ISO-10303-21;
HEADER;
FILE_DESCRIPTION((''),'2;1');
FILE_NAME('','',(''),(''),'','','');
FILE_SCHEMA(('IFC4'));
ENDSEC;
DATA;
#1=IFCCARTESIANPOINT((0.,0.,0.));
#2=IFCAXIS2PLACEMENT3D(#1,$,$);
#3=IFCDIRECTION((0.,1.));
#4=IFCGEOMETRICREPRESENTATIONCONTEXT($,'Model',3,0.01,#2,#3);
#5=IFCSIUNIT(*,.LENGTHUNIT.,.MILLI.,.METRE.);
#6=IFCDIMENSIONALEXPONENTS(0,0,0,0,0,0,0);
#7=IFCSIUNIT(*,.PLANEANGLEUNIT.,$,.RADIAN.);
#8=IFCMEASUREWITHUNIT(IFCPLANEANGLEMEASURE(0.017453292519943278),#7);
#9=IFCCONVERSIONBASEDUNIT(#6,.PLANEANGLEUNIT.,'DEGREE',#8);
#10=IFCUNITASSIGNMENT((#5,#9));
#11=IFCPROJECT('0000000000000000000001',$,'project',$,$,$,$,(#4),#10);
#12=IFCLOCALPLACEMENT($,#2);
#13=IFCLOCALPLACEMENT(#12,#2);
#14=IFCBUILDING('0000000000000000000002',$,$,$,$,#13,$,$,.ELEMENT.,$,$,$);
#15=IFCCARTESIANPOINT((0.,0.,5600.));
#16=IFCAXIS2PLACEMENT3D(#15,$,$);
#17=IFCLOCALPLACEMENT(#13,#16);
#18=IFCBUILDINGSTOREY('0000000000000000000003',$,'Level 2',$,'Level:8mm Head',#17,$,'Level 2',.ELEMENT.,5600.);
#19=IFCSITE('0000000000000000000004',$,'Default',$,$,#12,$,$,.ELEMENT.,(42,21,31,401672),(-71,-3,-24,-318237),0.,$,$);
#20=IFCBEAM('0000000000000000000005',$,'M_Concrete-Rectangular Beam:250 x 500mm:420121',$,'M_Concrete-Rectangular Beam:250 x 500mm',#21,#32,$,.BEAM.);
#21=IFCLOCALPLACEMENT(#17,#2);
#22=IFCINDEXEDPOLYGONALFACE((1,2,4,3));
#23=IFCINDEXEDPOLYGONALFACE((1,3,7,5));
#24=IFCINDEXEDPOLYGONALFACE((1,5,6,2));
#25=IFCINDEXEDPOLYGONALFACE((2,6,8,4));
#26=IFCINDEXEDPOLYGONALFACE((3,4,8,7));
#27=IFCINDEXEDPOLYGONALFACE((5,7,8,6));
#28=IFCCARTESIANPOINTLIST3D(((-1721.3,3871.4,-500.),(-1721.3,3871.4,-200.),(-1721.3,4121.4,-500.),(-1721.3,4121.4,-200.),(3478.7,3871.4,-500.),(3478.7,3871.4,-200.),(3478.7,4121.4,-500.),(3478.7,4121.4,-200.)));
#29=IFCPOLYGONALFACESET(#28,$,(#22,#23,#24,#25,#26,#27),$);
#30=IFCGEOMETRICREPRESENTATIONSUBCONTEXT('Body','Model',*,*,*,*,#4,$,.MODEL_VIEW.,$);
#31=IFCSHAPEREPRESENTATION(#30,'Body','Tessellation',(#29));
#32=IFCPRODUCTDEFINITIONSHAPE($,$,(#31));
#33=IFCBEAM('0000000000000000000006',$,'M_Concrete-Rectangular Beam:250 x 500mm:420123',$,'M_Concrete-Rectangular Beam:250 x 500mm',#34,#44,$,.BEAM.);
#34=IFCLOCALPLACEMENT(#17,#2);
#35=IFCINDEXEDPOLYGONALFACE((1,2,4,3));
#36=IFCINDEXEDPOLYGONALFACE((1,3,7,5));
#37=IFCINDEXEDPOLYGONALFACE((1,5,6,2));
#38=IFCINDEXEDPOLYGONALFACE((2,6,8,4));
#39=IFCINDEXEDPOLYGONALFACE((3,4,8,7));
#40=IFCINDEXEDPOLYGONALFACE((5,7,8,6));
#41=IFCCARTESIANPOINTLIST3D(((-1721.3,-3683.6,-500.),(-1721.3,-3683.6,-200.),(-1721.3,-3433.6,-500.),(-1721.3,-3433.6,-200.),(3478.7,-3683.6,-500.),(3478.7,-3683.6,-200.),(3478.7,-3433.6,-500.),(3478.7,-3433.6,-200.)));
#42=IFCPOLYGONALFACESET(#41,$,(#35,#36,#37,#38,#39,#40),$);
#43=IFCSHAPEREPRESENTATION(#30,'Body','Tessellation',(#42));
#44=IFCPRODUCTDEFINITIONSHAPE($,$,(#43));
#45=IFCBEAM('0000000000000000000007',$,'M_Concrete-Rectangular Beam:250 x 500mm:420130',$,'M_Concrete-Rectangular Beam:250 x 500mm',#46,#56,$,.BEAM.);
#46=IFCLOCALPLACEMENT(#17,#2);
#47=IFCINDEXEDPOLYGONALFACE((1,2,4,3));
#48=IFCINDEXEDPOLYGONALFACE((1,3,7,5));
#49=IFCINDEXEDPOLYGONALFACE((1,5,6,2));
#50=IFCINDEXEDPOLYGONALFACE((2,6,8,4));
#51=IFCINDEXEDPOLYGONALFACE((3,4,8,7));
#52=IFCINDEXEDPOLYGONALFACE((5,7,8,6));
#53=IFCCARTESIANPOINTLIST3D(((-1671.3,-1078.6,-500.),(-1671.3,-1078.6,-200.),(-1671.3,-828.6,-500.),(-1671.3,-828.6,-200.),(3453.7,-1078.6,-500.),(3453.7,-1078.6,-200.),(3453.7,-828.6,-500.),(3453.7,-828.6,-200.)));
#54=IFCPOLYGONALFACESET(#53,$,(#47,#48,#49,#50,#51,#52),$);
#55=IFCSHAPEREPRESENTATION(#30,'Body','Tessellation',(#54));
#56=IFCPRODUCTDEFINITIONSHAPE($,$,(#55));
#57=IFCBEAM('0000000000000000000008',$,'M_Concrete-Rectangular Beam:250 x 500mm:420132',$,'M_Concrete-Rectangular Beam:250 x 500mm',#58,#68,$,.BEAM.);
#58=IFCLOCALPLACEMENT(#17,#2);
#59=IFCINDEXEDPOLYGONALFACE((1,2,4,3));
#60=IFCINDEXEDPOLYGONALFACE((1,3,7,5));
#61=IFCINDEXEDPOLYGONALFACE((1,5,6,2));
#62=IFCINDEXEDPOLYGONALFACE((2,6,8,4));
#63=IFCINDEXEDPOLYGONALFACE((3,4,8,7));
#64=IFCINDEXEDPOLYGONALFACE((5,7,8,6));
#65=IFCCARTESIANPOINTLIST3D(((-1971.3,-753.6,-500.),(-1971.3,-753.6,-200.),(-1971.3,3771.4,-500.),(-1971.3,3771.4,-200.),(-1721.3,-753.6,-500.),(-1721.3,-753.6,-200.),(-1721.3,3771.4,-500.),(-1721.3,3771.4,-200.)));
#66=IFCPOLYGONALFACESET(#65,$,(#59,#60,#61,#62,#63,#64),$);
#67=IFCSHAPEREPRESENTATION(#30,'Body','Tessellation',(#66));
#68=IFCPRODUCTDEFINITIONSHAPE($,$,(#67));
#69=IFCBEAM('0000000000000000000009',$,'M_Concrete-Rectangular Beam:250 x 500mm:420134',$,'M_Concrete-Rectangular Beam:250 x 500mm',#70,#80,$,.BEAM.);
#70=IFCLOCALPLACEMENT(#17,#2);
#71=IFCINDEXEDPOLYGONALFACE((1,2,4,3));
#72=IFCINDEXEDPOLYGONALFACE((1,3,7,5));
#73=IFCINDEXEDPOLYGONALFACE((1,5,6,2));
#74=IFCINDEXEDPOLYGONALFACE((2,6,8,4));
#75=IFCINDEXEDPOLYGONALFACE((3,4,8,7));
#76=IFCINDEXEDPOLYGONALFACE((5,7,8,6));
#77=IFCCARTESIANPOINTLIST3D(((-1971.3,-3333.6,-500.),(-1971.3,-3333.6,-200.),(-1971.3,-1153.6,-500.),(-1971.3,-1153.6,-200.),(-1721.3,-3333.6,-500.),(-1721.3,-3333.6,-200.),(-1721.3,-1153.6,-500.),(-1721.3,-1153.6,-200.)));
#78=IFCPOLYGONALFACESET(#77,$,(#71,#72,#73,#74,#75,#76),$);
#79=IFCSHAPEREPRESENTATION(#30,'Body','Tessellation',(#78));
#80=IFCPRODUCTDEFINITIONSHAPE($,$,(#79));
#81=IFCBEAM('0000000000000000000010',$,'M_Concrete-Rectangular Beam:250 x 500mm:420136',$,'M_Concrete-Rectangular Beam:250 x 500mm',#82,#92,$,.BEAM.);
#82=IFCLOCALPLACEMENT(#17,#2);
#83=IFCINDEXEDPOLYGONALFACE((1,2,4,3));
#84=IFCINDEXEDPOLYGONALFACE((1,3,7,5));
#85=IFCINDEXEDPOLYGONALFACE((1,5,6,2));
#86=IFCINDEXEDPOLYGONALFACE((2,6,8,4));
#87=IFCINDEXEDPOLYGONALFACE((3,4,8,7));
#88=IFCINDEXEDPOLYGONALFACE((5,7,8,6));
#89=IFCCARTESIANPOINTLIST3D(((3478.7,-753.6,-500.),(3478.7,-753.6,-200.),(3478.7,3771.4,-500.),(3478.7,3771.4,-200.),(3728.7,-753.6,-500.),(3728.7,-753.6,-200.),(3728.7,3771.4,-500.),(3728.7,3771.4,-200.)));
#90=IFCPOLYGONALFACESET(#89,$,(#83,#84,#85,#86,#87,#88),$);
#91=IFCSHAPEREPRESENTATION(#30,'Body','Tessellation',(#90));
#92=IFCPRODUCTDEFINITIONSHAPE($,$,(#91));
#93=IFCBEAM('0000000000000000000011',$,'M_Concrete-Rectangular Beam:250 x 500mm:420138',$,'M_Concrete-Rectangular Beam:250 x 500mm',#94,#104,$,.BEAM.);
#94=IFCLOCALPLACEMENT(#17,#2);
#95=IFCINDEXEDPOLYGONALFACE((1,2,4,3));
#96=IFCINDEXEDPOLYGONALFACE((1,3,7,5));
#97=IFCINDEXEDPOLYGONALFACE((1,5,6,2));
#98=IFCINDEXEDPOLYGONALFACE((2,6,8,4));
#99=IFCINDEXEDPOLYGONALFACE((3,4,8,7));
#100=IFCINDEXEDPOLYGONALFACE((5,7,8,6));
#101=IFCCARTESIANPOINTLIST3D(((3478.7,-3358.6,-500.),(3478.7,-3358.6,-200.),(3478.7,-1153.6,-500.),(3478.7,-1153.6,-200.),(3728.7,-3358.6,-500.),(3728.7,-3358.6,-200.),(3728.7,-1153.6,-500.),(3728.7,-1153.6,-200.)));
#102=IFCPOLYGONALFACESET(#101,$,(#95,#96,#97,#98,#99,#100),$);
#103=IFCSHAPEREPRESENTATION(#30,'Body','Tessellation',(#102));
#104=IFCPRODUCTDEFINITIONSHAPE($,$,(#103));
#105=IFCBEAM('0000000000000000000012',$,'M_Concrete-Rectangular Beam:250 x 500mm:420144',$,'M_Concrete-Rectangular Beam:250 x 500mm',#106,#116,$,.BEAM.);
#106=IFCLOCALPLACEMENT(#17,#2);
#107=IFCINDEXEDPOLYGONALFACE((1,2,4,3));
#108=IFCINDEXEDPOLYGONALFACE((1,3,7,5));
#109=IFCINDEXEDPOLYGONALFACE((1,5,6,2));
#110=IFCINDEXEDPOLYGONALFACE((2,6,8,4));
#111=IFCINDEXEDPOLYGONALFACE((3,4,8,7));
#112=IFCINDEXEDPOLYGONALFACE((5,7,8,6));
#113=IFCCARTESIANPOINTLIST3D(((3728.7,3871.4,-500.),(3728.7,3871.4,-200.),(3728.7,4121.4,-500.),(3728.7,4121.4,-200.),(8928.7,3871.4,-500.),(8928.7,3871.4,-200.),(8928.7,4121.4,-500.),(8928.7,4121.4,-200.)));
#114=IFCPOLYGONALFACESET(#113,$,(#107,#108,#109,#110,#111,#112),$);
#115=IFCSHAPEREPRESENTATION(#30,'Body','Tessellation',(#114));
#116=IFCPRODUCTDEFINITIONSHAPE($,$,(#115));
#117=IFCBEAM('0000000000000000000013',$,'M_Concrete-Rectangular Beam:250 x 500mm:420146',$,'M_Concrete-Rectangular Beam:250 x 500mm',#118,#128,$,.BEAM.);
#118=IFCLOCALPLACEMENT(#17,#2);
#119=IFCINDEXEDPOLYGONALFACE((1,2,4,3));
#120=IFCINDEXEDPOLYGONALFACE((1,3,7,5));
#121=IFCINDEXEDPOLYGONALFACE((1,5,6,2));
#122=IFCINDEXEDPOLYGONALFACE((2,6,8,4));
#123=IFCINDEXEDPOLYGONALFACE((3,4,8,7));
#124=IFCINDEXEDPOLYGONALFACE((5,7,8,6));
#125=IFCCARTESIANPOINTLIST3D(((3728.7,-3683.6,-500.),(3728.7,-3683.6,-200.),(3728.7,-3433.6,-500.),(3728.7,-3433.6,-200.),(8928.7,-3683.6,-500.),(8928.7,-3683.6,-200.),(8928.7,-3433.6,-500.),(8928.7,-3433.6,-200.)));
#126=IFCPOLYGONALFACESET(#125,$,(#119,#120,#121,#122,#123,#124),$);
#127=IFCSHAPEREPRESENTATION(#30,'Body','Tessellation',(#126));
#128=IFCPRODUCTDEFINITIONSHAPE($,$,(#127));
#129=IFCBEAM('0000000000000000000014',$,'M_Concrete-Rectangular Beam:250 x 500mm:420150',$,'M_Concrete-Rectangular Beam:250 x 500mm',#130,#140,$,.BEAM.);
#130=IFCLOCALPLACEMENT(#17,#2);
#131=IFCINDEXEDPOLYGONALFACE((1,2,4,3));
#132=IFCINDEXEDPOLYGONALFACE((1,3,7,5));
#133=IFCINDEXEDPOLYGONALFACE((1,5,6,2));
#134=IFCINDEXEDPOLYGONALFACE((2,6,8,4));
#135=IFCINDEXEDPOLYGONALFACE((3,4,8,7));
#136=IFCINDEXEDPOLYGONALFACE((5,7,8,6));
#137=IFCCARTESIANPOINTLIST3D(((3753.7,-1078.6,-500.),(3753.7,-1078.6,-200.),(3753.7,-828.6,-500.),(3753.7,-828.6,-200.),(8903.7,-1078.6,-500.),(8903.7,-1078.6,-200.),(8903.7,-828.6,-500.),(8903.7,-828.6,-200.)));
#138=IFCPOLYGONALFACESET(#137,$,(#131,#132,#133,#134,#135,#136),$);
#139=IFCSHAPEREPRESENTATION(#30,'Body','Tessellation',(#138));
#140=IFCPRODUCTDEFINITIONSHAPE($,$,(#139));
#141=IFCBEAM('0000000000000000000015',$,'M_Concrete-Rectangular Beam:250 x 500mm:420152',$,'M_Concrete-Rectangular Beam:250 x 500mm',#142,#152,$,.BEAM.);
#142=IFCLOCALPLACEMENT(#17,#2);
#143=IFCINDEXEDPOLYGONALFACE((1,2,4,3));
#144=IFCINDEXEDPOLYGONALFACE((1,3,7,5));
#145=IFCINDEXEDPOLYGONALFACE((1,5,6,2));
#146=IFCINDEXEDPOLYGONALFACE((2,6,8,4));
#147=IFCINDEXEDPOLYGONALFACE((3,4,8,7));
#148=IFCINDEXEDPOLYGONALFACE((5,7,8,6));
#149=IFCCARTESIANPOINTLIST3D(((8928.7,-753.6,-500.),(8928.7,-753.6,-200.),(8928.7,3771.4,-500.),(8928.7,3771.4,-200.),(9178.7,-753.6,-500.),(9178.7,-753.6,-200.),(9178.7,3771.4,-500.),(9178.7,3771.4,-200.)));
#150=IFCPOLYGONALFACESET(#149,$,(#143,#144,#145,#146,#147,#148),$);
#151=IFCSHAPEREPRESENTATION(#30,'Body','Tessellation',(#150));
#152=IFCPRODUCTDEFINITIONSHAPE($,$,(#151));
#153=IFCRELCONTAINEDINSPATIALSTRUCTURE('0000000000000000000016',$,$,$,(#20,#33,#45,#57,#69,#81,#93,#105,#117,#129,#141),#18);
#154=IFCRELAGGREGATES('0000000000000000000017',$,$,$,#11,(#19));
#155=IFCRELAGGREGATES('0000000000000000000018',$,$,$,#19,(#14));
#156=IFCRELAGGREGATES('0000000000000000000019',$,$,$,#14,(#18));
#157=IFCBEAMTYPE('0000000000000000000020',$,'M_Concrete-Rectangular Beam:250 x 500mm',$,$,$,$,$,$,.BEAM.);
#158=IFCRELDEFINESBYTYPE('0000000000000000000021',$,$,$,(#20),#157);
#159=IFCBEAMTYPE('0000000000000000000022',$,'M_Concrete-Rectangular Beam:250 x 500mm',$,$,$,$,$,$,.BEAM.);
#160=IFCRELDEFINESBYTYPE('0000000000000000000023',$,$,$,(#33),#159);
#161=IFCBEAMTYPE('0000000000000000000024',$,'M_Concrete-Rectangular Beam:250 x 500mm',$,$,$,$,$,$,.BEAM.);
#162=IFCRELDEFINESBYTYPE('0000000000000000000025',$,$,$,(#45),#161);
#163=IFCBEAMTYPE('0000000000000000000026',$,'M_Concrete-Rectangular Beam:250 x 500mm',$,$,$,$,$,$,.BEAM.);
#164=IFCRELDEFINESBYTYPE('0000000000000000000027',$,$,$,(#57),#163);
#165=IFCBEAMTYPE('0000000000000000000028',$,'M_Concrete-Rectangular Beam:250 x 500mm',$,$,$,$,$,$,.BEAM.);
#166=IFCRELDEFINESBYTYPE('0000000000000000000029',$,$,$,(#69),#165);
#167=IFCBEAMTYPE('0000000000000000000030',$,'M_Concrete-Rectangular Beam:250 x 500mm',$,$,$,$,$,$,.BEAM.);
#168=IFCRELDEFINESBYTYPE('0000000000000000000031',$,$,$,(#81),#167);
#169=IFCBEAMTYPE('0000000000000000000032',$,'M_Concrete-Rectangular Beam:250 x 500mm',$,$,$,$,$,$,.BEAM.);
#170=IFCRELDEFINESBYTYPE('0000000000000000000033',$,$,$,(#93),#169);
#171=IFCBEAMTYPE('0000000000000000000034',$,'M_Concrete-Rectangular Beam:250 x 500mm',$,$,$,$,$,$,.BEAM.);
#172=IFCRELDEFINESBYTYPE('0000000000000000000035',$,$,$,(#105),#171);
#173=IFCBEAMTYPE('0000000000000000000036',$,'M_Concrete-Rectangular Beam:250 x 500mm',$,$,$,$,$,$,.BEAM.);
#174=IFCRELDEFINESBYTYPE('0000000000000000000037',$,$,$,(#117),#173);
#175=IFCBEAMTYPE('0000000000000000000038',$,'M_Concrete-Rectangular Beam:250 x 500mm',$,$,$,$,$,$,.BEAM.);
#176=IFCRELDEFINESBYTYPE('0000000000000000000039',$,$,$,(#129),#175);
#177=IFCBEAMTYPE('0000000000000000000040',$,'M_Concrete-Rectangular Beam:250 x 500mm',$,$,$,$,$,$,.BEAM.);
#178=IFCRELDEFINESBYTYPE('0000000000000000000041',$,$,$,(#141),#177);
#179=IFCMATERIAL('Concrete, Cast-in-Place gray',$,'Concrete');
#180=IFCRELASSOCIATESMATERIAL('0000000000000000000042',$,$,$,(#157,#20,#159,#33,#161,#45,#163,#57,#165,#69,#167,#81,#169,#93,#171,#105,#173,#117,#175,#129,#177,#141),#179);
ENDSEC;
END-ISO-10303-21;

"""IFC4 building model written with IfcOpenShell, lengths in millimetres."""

from ifc_helpers import new_model, entity, si_unit, converted_unit, direction, frame, origin, place, context, subcontext, project, spatial, indexed_curve, outline, extrude, source, transform, mapped, material, type_object, type_shapes, element, save


model = new_model("IFC4")

# Units and contexts
model_context = context("Model", 3, precision=0.01, world=origin(), true_north=direction((0.0, 1.0)))
body_context = subcontext(model_context, "Body", "Model", "MODEL_VIEW")
ifc_project = project(units=[si_unit("LENGTHUNIT", "METRE", prefix="MILLI"), converted_unit("PLANEANGLEUNIT", "DEGREE", entity("IfcPlaneAngleMeasure", 0.017453292519943278), si_unit("PLANEANGLEUNIT", "RADIAN"), dimensions=[0, 0, 0, 0, 0, 0, 0])], contexts=[model_context])

# Site, building, storey
site_placement = place(None, origin())
site = spatial("IfcSite", under=ifc_project, at=site_placement, Name="Default", CompositionType="ELEMENT", RefLatitude=(42, 21, 31, 401672), RefLongitude=(-71, -3, -24, -318237), RefElevation=0.0)
building_placement = place(site_placement, origin())
building = spatial("IfcBuilding", under=site, at=building_placement, CompositionType="ELEMENT")
storey_placement = place(building_placement, frame((0.0, 0.0, 5600.0)))
storey = spatial("IfcBuildingStorey", under=building, at=storey_placement, Name="Level 2", ObjectType="Level:8mm Head", LongName="Level 2", CompositionType="ELEMENT", Elevation=5600.0)

# Beams
ifc_material_1 = material(Name="Concrete, Cast-in-Place gray", Category="Concrete")
beam_type_1 = type_object("IfcBeamType", Name="M_Concrete-Rectangular Beam:250 x 500mm", PredefinedType="BEAM", material=ifc_material_1)
shared_shape_1 = source(origin(), body_context, "Body", "SweptSolid", [
    extrude(outline(indexed_curve([(-150.0, -125.0), (150.0, -125.0), (150.0, 125.0), (-150.0, 125.0), (-150.0, -125.0)], self_intersect=False)), frame((-1721.3, 3996.4, 5250.0), z_axis=(1.0, 0.0, 0.0), x_axis=(0.0, 0.0, -1.0)), (0.0, 0.0, 1.0), 5200.0),
])
type_shapes(beam_type_1, [shared_shape_1])
beam_1_placement = place(storey_placement, frame((0.0, 0.0, -5600.0)))
element("IfcBeam", 1, at=beam_1_placement, inside=storey, type_object=beam_type_1, material=ifc_material_1, Name="M_Concrete-Rectangular Beam:250 x 500mm:420121", ObjectType="M_Concrete-Rectangular Beam:250 x 500mm", PredefinedType="BEAM", context=body_context, shape_type="MappedRepresentation", body=[
    mapped(shared_shape_1, transform((0.0, 0.0, 0.0), scale=1.0)),
])
beam_type_2 = type_object("IfcBeamType", Name="M_Concrete-Rectangular Beam:250 x 500mm", PredefinedType="BEAM", material=ifc_material_1)
shared_shape_2 = source(origin(), body_context, "Body", "SweptSolid", [
    extrude(outline(indexed_curve([(-150.0, -125.0), (150.0, -125.0), (150.0, 125.0), (-150.0, 125.0), (-150.0, -125.0)], self_intersect=False)), frame((-1721.3, -3558.6, 5250.0), z_axis=(1.0, 0.0, 0.0), x_axis=(0.0, 0.0, -1.0)), (0.0, 0.0, 1.0), 5200.0),
])
type_shapes(beam_type_2, [shared_shape_2])
beam_2_placement = place(storey_placement, frame((0.0, 0.0, -5600.0)))
element("IfcBeam", 2, at=beam_2_placement, inside=storey, type_object=beam_type_2, material=ifc_material_1, Name="M_Concrete-Rectangular Beam:250 x 500mm:420123", ObjectType="M_Concrete-Rectangular Beam:250 x 500mm", PredefinedType="BEAM", context=body_context, shape_type="MappedRepresentation", body=[
    mapped(shared_shape_2, transform((0.0, 0.0, 0.0), scale=1.0)),
])
beam_type_3 = type_object("IfcBeamType", Name="M_Concrete-Rectangular Beam:250 x 500mm", PredefinedType="BEAM", material=ifc_material_1)
shared_shape_3 = source(origin(), body_context, "Body", "SweptSolid", [
    extrude(outline(indexed_curve([(-150.0, -125.0), (150.0, -125.0), (150.0, 125.0), (-150.0, 125.0), (-150.0, -125.0)], self_intersect=False)), frame((-1671.3, -953.6, 5250.0), z_axis=(1.0, 0.0, 0.0), x_axis=(0.0, 0.0, -1.0)), (0.0, 0.0, 1.0), 5125.0),
])
type_shapes(beam_type_3, [shared_shape_3])
beam_3_placement = place(storey_placement, frame((0.0, 0.0, -5600.0)))
element("IfcBeam", 3, at=beam_3_placement, inside=storey, type_object=beam_type_3, material=ifc_material_1, Name="M_Concrete-Rectangular Beam:250 x 500mm:420130", ObjectType="M_Concrete-Rectangular Beam:250 x 500mm", PredefinedType="BEAM", context=body_context, shape_type="MappedRepresentation", body=[
    mapped(shared_shape_3, transform((0.0, 0.0, 0.0), scale=1.0)),
])
beam_type_4 = type_object("IfcBeamType", Name="M_Concrete-Rectangular Beam:250 x 500mm", PredefinedType="BEAM", material=ifc_material_1)
shared_shape_4 = source(origin(), body_context, "Body", "SweptSolid", [
    extrude(outline(indexed_curve([(-125.0, -150.0), (125.0, -150.0), (125.0, 150.0), (-125.0, 150.0), (-125.0, -150.0)], self_intersect=False)), frame((-1846.3, 3771.4, 5250.0), z_axis=(0.0, -1.0, 0.0), x_axis=(-1.0, 0.0, 0.0)), (0.0, 0.0, 1.0), 4525.0),
])
type_shapes(beam_type_4, [shared_shape_4])
beam_4_placement = place(storey_placement, frame((0.0, 0.0, -5600.0)))
element("IfcBeam", 4, at=beam_4_placement, inside=storey, type_object=beam_type_4, material=ifc_material_1, Name="M_Concrete-Rectangular Beam:250 x 500mm:420132", ObjectType="M_Concrete-Rectangular Beam:250 x 500mm", PredefinedType="BEAM", context=body_context, shape_type="MappedRepresentation", body=[
    mapped(shared_shape_4, transform((0.0, 0.0, 0.0), scale=1.0)),
])
beam_type_5 = type_object("IfcBeamType", Name="M_Concrete-Rectangular Beam:250 x 500mm", PredefinedType="BEAM", material=ifc_material_1)
shared_shape_5 = source(origin(), body_context, "Body", "SweptSolid", [
    extrude(outline(indexed_curve([(-125.0, -150.0), (125.0, -150.0), (125.0, 150.0), (-125.0, 150.0), (-125.0, -150.0)], self_intersect=False)), frame((-1846.3, -1153.6, 5250.0), z_axis=(0.0, -1.0, 0.0), x_axis=(-1.0, 0.0, 0.0)), (0.0, 0.0, 1.0), 2180.0),
])
type_shapes(beam_type_5, [shared_shape_5])
beam_5_placement = place(storey_placement, frame((0.0, 0.0, -5600.0)))
element("IfcBeam", 5, at=beam_5_placement, inside=storey, type_object=beam_type_5, material=ifc_material_1, Name="M_Concrete-Rectangular Beam:250 x 500mm:420134", ObjectType="M_Concrete-Rectangular Beam:250 x 500mm", PredefinedType="BEAM", context=body_context, shape_type="MappedRepresentation", body=[
    mapped(shared_shape_5, transform((0.0, 0.0, 0.0), scale=1.0)),
])
beam_type_6 = type_object("IfcBeamType", Name="M_Concrete-Rectangular Beam:250 x 500mm", PredefinedType="BEAM", material=ifc_material_1)
shared_shape_6 = source(origin(), body_context, "Body", "SweptSolid", [
    extrude(outline(indexed_curve([(-125.0, -150.0), (125.0, -150.0), (125.0, 150.0), (-125.0, 150.0), (-125.0, -150.0)], self_intersect=False)), frame((3603.7, 3771.4, 5250.0), z_axis=(0.0, -1.0, 0.0), x_axis=(-1.0, 0.0, 0.0)), (0.0, 0.0, 1.0), 4525.0),
])
type_shapes(beam_type_6, [shared_shape_6])
beam_6_placement = place(storey_placement, frame((0.0, 0.0, -5600.0)))
element("IfcBeam", 6, at=beam_6_placement, inside=storey, type_object=beam_type_6, material=ifc_material_1, Name="M_Concrete-Rectangular Beam:250 x 500mm:420136", ObjectType="M_Concrete-Rectangular Beam:250 x 500mm", PredefinedType="BEAM", context=body_context, shape_type="MappedRepresentation", body=[
    mapped(shared_shape_6, transform((0.0, 0.0, 0.0), scale=1.0)),
])
beam_type_7 = type_object("IfcBeamType", Name="M_Concrete-Rectangular Beam:250 x 500mm", PredefinedType="BEAM", material=ifc_material_1)
shared_shape_7 = source(origin(), body_context, "Body", "SweptSolid", [
    extrude(outline(indexed_curve([(-125.0, -150.0), (125.0, -150.0), (125.0, 150.0), (-125.0, 150.0), (-125.0, -150.0)], self_intersect=False)), frame((3603.7, -1153.6, 5250.0), z_axis=(0.0, -1.0, 0.0), x_axis=(-1.0, 0.0, 0.0)), (0.0, 0.0, 1.0), 2205.0),
])
type_shapes(beam_type_7, [shared_shape_7])
beam_7_placement = place(storey_placement, frame((0.0, 0.0, -5600.0)))
element("IfcBeam", 7, at=beam_7_placement, inside=storey, type_object=beam_type_7, material=ifc_material_1, Name="M_Concrete-Rectangular Beam:250 x 500mm:420138", ObjectType="M_Concrete-Rectangular Beam:250 x 500mm", PredefinedType="BEAM", context=body_context, shape_type="MappedRepresentation", body=[
    mapped(shared_shape_7, transform((0.0, 0.0, 0.0), scale=1.0)),
])
beam_type_8 = type_object("IfcBeamType", Name="M_Concrete-Rectangular Beam:250 x 500mm", PredefinedType="BEAM", material=ifc_material_1)
shared_shape_8 = source(origin(), body_context, "Body", "SweptSolid", [
    extrude(outline(indexed_curve([(-150.0, -125.0), (150.0, -125.0), (150.0, 125.0), (-150.0, 125.0), (-150.0, -125.0)], self_intersect=False)), frame((3728.7, 3996.4, 5250.0), z_axis=(1.0, 0.0, 0.0), x_axis=(0.0, 0.0, -1.0)), (0.0, 0.0, 1.0), 5200.0),
])
type_shapes(beam_type_8, [shared_shape_8])
beam_8_placement = place(storey_placement, frame((0.0, 0.0, -5600.0)))
element("IfcBeam", 8, at=beam_8_placement, inside=storey, type_object=beam_type_8, material=ifc_material_1, Name="M_Concrete-Rectangular Beam:250 x 500mm:420144", ObjectType="M_Concrete-Rectangular Beam:250 x 500mm", PredefinedType="BEAM", context=body_context, shape_type="MappedRepresentation", body=[
    mapped(shared_shape_8, transform((0.0, 0.0, 0.0), scale=1.0)),
])
beam_type_9 = type_object("IfcBeamType", Name="M_Concrete-Rectangular Beam:250 x 500mm", PredefinedType="BEAM", material=ifc_material_1)
shared_shape_9 = source(origin(), body_context, "Body", "SweptSolid", [
    extrude(outline(indexed_curve([(-150.0, -125.0), (150.0, -125.0), (150.0, 125.0), (-150.0, 125.0), (-150.0, -125.0)], self_intersect=False)), frame((3728.7, -3558.6, 5250.0), z_axis=(1.0, 0.0, 0.0), x_axis=(0.0, 0.0, -1.0)), (0.0, 0.0, 1.0), 5200.0),
])
type_shapes(beam_type_9, [shared_shape_9])
beam_9_placement = place(storey_placement, frame((0.0, 0.0, -5600.0)))
element("IfcBeam", 9, at=beam_9_placement, inside=storey, type_object=beam_type_9, material=ifc_material_1, Name="M_Concrete-Rectangular Beam:250 x 500mm:420146", ObjectType="M_Concrete-Rectangular Beam:250 x 500mm", PredefinedType="BEAM", context=body_context, shape_type="MappedRepresentation", body=[
    mapped(shared_shape_9, transform((0.0, 0.0, 0.0), scale=1.0)),
])
beam_type_10 = type_object("IfcBeamType", Name="M_Concrete-Rectangular Beam:250 x 500mm", PredefinedType="BEAM", material=ifc_material_1)
shared_shape_10 = source(origin(), body_context, "Body", "SweptSolid", [
    extrude(outline(indexed_curve([(-150.0, -125.0), (150.0, -125.0), (150.0, 125.0), (-150.0, 125.0), (-150.0, -125.0)], self_intersect=False)), frame((3753.7, -953.6, 5250.0), z_axis=(1.0, 0.0, 0.0), x_axis=(0.0, 0.0, -1.0)), (0.0, 0.0, 1.0), 5150.0),
])
type_shapes(beam_type_10, [shared_shape_10])
beam_10_placement = place(storey_placement, frame((0.0, 0.0, -5600.0)))
element("IfcBeam", 10, at=beam_10_placement, inside=storey, type_object=beam_type_10, material=ifc_material_1, Name="M_Concrete-Rectangular Beam:250 x 500mm:420150", ObjectType="M_Concrete-Rectangular Beam:250 x 500mm", PredefinedType="BEAM", context=body_context, shape_type="MappedRepresentation", body=[
    mapped(shared_shape_10, transform((0.0, 0.0, 0.0), scale=1.0)),
])
beam_type_11 = type_object("IfcBeamType", Name="M_Concrete-Rectangular Beam:250 x 500mm", PredefinedType="BEAM", material=ifc_material_1)
shared_shape_11 = source(origin(), body_context, "Body", "SweptSolid", [
    extrude(outline(indexed_curve([(-125.0, -150.0), (125.0, -150.0), (125.0, 150.0), (-125.0, 150.0), (-125.0, -150.0)], self_intersect=False)), frame((9053.7, 3771.4, 5250.0), z_axis=(0.0, -1.0, 0.0), x_axis=(-1.0, 0.0, 0.0)), (0.0, 0.0, 1.0), 4525.0),
])
type_shapes(beam_type_11, [shared_shape_11])
beam_11_placement = place(storey_placement, frame((0.0, 0.0, -5600.0)))
element("IfcBeam", 11, at=beam_11_placement, inside=storey, type_object=beam_type_11, material=ifc_material_1, Name="M_Concrete-Rectangular Beam:250 x 500mm:420152", ObjectType="M_Concrete-Rectangular Beam:250 x 500mm", PredefinedType="BEAM", context=body_context, shape_type="MappedRepresentation", body=[
    mapped(shared_shape_11, transform((0.0, 0.0, 0.0), scale=1.0)),
])

save(model, "model.ifc")
